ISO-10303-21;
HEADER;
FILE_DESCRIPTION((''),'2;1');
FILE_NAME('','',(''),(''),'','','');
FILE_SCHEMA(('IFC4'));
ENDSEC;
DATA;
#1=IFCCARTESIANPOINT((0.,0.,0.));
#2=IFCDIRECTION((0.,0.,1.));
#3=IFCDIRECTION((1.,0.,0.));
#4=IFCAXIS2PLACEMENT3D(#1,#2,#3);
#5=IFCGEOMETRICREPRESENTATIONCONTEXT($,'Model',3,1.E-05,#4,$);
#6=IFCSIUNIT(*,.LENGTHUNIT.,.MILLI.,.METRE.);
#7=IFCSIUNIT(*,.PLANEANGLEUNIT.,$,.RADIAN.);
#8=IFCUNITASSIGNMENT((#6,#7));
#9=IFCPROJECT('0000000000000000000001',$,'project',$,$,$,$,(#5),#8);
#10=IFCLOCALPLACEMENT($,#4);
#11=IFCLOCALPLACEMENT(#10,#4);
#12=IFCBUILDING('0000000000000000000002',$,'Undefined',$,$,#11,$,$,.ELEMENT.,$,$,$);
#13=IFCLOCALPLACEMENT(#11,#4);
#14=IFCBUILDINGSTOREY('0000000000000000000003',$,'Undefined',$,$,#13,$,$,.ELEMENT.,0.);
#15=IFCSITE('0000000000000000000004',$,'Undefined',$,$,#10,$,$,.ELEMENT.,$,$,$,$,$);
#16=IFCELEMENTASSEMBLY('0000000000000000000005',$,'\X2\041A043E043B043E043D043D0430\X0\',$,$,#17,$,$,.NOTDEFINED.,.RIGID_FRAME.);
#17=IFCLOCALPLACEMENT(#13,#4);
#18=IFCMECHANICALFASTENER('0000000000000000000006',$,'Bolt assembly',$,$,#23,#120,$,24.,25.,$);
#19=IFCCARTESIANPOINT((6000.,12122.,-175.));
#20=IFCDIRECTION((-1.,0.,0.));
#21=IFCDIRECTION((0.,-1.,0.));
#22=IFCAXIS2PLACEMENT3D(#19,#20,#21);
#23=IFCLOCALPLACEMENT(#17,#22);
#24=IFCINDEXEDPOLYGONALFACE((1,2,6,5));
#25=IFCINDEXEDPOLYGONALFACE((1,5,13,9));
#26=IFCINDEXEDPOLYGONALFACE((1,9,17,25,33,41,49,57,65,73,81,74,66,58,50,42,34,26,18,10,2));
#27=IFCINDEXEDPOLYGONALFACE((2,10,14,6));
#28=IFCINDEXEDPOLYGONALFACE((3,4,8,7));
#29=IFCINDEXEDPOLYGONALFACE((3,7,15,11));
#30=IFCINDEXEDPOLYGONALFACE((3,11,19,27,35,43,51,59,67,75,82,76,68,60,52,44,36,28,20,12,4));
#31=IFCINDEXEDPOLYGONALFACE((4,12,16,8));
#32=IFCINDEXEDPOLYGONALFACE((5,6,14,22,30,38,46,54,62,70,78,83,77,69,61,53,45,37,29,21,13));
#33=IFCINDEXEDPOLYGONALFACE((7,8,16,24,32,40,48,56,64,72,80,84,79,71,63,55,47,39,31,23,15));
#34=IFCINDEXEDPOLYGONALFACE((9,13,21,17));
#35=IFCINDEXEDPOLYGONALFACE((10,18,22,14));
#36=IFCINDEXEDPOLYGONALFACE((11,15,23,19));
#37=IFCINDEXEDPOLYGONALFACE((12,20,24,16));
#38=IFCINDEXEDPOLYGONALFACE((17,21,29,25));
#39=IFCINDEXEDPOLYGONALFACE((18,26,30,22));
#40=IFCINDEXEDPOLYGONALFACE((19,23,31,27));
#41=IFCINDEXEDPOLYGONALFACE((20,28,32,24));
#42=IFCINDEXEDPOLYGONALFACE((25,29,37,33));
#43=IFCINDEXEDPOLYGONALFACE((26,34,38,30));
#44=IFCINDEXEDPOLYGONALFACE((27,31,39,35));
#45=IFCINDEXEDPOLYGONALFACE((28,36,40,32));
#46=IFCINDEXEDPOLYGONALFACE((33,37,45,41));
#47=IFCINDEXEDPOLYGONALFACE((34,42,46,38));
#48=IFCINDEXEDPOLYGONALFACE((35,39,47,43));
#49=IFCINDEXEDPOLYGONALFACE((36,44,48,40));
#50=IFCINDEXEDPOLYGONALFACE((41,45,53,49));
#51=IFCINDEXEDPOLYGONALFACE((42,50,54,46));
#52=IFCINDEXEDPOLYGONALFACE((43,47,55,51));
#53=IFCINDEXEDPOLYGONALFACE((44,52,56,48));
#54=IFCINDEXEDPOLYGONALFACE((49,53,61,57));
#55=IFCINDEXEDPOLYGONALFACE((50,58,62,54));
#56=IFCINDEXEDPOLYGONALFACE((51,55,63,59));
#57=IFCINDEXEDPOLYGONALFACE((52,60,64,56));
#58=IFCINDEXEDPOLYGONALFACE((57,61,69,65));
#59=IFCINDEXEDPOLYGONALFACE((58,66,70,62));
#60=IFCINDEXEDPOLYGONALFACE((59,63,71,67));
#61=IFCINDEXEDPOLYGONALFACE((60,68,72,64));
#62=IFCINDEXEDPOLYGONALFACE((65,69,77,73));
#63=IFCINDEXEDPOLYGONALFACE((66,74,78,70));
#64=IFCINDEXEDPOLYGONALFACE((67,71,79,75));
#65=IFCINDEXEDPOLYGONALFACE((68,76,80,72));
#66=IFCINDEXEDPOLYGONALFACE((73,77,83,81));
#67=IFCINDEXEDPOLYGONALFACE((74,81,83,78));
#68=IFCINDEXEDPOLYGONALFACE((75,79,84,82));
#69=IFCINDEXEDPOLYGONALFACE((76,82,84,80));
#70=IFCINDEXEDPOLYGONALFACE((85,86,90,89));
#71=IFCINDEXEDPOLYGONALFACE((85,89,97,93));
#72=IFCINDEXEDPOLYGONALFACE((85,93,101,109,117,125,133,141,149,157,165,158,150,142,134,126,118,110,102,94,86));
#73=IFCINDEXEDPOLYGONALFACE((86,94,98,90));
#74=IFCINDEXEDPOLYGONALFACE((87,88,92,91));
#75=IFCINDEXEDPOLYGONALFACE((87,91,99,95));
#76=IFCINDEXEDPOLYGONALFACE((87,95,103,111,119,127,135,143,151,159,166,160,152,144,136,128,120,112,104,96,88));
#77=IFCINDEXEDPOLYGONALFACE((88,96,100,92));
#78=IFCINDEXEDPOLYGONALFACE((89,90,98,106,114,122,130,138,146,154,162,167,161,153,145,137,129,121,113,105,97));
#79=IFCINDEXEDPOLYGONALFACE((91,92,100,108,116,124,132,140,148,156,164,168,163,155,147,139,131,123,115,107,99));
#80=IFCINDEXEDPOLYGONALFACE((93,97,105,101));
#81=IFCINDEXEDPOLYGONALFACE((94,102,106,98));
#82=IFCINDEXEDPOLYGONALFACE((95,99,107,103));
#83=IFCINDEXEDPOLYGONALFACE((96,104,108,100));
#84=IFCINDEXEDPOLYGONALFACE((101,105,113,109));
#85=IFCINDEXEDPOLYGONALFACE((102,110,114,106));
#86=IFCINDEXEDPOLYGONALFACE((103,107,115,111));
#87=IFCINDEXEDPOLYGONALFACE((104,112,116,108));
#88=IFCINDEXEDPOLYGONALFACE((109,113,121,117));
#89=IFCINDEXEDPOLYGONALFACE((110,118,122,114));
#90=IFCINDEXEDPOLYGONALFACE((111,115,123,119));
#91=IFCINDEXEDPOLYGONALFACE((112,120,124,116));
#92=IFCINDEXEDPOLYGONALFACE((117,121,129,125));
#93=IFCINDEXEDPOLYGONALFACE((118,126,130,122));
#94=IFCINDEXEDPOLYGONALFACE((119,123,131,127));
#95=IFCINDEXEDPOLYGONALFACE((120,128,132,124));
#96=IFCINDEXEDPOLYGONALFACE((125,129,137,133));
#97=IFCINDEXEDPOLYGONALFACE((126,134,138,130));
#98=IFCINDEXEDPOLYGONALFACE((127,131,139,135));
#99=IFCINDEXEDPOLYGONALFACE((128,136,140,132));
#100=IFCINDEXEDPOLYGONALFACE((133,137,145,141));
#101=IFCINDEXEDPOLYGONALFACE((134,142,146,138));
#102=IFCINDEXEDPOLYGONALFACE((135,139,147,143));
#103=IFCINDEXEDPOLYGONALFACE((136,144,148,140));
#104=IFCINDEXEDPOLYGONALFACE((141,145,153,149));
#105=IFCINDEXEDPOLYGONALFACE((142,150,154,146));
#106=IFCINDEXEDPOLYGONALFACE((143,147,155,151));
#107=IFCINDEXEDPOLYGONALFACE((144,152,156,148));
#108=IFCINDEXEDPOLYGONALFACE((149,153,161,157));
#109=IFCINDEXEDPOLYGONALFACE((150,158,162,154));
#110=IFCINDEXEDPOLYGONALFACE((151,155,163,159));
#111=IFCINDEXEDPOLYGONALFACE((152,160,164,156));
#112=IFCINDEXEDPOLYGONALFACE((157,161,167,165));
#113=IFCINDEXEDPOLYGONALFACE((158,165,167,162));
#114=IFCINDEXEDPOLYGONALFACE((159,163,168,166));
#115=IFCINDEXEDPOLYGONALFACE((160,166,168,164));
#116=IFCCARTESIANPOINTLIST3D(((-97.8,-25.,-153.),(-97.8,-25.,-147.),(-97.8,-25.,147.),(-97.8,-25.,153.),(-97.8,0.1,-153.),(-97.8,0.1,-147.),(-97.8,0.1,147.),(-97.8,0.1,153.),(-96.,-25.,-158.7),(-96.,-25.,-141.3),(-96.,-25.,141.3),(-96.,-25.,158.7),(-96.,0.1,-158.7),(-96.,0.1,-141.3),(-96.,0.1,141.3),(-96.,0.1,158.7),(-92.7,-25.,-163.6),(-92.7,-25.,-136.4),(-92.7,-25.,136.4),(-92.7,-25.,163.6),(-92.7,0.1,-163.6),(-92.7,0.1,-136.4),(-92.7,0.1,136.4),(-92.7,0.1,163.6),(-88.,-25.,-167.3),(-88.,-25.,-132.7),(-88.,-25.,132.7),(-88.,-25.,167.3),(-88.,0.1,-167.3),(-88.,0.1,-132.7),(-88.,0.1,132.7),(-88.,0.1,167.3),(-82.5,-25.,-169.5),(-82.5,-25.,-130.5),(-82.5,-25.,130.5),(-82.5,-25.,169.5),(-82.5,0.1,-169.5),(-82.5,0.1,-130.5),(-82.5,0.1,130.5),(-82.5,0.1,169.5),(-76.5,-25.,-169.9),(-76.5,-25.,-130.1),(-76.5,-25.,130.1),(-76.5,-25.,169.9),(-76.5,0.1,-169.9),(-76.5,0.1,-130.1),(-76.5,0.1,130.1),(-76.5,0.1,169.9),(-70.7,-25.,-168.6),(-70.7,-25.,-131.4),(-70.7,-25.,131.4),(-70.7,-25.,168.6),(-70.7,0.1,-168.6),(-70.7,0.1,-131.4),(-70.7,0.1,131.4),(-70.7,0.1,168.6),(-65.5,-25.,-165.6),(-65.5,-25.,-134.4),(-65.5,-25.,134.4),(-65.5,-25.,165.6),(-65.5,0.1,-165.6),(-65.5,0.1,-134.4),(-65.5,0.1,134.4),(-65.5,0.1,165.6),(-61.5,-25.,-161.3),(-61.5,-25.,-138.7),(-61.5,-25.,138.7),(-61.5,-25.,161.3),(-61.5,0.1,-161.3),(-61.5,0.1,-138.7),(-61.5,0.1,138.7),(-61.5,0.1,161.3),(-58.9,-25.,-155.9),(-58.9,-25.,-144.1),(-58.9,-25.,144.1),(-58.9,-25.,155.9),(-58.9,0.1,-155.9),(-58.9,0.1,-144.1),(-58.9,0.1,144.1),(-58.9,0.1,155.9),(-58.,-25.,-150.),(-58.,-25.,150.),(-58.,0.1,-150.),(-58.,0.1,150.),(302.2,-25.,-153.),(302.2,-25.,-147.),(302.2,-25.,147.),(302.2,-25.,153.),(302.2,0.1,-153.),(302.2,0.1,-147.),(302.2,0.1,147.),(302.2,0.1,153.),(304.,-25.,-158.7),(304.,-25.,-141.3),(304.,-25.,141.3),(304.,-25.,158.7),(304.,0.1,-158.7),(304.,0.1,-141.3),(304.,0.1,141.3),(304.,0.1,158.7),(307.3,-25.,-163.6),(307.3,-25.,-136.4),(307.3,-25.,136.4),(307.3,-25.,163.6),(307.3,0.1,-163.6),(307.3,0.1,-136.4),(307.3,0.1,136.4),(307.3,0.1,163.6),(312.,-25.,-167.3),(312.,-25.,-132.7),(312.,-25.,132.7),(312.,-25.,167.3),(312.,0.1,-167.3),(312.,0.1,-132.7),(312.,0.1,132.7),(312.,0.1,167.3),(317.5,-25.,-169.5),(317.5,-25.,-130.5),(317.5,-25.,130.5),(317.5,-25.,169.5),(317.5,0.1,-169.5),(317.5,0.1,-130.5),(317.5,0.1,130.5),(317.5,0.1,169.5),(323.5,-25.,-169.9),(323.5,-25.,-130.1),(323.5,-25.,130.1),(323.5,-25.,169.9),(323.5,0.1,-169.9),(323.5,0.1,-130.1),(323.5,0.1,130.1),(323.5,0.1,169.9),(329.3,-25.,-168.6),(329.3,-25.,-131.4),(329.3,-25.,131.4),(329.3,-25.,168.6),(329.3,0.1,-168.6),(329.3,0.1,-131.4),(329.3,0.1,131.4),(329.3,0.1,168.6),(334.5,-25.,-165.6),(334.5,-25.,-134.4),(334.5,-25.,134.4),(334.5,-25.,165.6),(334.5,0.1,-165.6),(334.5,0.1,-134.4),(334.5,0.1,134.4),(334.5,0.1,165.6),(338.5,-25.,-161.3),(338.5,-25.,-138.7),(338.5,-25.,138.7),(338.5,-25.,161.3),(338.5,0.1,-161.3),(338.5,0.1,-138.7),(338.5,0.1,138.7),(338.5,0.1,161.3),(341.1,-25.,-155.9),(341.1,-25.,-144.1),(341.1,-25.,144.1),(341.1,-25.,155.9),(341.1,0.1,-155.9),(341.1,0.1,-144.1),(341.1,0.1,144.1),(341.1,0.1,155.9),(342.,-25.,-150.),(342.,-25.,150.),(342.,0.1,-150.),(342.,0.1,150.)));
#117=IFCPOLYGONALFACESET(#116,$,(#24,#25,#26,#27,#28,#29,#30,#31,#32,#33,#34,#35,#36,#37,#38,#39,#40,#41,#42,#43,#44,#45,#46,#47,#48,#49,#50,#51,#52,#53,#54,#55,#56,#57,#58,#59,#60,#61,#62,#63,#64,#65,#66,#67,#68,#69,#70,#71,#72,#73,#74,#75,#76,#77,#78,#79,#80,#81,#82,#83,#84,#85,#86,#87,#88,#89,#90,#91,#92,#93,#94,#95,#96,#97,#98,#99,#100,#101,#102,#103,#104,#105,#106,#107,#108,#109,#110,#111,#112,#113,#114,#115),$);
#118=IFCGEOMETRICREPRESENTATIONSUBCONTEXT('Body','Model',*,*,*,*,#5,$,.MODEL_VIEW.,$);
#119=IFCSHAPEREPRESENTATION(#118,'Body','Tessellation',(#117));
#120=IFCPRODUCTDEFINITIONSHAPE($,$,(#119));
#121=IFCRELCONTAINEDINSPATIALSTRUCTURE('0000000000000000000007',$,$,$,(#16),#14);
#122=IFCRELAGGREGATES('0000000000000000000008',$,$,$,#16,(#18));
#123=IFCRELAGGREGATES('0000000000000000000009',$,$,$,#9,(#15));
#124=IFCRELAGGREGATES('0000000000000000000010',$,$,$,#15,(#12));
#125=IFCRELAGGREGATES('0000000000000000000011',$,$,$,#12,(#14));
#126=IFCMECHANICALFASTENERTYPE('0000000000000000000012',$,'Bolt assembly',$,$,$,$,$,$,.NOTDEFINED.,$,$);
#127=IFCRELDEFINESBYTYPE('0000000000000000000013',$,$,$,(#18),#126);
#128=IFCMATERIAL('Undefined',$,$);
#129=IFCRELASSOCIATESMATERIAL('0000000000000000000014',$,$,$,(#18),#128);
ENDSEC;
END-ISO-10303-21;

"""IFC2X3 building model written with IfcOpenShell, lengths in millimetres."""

from ifc_helpers import new_model, si_unit, frame, origin_with_axes, origin_2d_with_axis, place, context, subcontext, project, spatial, circle, extrude, source, transform, mapped, material, type_object, element, aggregate, save


model = new_model("IFC2X3")

# Units and contexts
model_context = context("Model", 3, precision=1e-05, world=origin_with_axes())
body_context = subcontext(model_context, "Body", "Model", "MODEL_VIEW")
ifc_project = project(units=[si_unit("LENGTHUNIT", "METRE", prefix="MILLI"), si_unit("PLANEANGLEUNIT", "RADIAN")], contexts=[model_context])

# Site, building, storey
site_placement = place(None, origin_with_axes())
site = spatial("IfcSite", under=ifc_project, at=site_placement, Name="Undefined", CompositionType="ELEMENT")
building_placement = place(site_placement, origin_with_axes())
building = spatial("IfcBuilding", under=site, at=building_placement, Name="Undefined", CompositionType="ELEMENT")
storey_placement = place(building_placement, origin_with_axes())
storey = spatial("IfcBuildingStorey", under=building, at=storey_placement, Name="Undefined", CompositionType="ELEMENT", Elevation=0.0)

# Shared definitions
ifc_material_1 = material(Name="Undefined")
mechanical_fastener_type = type_object("IfcMechanicalFastenerType", Name="Bolt assembly")

# Element assembly, mechanical fastener
shared_shape_1 = source(origin_with_axes(), body_context, "Body", "SweptSolid", [
    extrude(circle(Radius=20.0, at=origin_2d_with_axis()), frame((0.0, -25.0, 0.0), z_axis=(0.0, 1.0, 0.0), x_axis=(1.0, 0.0, 0.0)), (0.0, 0.0, 1.0), 25.1),
])
assembly_1_placement = place(storey_placement, origin_with_axes())
assembly_1 = element("IfcElementAssembly", 1, at=assembly_1_placement, inside=storey, Name="Колонна", AssemblyPlace="NOTDEFINED", PredefinedType="RIGID_FRAME")
mechanical_fastener_1_placement = place(assembly_1_placement, frame((6000.0, 12122.0, -175.0), z_axis=(-1.0, 0.0, 0.0), x_axis=(0.0, -1.0, 0.0)))
mechanical_fastener_1 = element("IfcMechanicalFastener", 2, at=mechanical_fastener_1_placement, type_object=mechanical_fastener_type, material=ifc_material_1, Name="Bolt assembly", NominalDiameter=24.0, NominalLength=25.0, context=body_context, shape_type="MappedRepresentation", body=[
    mapped(shared_shape_1, transform((-78.0, 0.0, -150.0))),
    mapped(shared_shape_1, transform((-78.0, 0.0, 150.0))),
    mapped(shared_shape_1, transform((322.0, 0.0, -150.0))),
    mapped(shared_shape_1, transform((322.0, 0.0, 150.0))),
])
aggregate(assembly_1, [mechanical_fastener_1])

save(model, "model.ifc")
